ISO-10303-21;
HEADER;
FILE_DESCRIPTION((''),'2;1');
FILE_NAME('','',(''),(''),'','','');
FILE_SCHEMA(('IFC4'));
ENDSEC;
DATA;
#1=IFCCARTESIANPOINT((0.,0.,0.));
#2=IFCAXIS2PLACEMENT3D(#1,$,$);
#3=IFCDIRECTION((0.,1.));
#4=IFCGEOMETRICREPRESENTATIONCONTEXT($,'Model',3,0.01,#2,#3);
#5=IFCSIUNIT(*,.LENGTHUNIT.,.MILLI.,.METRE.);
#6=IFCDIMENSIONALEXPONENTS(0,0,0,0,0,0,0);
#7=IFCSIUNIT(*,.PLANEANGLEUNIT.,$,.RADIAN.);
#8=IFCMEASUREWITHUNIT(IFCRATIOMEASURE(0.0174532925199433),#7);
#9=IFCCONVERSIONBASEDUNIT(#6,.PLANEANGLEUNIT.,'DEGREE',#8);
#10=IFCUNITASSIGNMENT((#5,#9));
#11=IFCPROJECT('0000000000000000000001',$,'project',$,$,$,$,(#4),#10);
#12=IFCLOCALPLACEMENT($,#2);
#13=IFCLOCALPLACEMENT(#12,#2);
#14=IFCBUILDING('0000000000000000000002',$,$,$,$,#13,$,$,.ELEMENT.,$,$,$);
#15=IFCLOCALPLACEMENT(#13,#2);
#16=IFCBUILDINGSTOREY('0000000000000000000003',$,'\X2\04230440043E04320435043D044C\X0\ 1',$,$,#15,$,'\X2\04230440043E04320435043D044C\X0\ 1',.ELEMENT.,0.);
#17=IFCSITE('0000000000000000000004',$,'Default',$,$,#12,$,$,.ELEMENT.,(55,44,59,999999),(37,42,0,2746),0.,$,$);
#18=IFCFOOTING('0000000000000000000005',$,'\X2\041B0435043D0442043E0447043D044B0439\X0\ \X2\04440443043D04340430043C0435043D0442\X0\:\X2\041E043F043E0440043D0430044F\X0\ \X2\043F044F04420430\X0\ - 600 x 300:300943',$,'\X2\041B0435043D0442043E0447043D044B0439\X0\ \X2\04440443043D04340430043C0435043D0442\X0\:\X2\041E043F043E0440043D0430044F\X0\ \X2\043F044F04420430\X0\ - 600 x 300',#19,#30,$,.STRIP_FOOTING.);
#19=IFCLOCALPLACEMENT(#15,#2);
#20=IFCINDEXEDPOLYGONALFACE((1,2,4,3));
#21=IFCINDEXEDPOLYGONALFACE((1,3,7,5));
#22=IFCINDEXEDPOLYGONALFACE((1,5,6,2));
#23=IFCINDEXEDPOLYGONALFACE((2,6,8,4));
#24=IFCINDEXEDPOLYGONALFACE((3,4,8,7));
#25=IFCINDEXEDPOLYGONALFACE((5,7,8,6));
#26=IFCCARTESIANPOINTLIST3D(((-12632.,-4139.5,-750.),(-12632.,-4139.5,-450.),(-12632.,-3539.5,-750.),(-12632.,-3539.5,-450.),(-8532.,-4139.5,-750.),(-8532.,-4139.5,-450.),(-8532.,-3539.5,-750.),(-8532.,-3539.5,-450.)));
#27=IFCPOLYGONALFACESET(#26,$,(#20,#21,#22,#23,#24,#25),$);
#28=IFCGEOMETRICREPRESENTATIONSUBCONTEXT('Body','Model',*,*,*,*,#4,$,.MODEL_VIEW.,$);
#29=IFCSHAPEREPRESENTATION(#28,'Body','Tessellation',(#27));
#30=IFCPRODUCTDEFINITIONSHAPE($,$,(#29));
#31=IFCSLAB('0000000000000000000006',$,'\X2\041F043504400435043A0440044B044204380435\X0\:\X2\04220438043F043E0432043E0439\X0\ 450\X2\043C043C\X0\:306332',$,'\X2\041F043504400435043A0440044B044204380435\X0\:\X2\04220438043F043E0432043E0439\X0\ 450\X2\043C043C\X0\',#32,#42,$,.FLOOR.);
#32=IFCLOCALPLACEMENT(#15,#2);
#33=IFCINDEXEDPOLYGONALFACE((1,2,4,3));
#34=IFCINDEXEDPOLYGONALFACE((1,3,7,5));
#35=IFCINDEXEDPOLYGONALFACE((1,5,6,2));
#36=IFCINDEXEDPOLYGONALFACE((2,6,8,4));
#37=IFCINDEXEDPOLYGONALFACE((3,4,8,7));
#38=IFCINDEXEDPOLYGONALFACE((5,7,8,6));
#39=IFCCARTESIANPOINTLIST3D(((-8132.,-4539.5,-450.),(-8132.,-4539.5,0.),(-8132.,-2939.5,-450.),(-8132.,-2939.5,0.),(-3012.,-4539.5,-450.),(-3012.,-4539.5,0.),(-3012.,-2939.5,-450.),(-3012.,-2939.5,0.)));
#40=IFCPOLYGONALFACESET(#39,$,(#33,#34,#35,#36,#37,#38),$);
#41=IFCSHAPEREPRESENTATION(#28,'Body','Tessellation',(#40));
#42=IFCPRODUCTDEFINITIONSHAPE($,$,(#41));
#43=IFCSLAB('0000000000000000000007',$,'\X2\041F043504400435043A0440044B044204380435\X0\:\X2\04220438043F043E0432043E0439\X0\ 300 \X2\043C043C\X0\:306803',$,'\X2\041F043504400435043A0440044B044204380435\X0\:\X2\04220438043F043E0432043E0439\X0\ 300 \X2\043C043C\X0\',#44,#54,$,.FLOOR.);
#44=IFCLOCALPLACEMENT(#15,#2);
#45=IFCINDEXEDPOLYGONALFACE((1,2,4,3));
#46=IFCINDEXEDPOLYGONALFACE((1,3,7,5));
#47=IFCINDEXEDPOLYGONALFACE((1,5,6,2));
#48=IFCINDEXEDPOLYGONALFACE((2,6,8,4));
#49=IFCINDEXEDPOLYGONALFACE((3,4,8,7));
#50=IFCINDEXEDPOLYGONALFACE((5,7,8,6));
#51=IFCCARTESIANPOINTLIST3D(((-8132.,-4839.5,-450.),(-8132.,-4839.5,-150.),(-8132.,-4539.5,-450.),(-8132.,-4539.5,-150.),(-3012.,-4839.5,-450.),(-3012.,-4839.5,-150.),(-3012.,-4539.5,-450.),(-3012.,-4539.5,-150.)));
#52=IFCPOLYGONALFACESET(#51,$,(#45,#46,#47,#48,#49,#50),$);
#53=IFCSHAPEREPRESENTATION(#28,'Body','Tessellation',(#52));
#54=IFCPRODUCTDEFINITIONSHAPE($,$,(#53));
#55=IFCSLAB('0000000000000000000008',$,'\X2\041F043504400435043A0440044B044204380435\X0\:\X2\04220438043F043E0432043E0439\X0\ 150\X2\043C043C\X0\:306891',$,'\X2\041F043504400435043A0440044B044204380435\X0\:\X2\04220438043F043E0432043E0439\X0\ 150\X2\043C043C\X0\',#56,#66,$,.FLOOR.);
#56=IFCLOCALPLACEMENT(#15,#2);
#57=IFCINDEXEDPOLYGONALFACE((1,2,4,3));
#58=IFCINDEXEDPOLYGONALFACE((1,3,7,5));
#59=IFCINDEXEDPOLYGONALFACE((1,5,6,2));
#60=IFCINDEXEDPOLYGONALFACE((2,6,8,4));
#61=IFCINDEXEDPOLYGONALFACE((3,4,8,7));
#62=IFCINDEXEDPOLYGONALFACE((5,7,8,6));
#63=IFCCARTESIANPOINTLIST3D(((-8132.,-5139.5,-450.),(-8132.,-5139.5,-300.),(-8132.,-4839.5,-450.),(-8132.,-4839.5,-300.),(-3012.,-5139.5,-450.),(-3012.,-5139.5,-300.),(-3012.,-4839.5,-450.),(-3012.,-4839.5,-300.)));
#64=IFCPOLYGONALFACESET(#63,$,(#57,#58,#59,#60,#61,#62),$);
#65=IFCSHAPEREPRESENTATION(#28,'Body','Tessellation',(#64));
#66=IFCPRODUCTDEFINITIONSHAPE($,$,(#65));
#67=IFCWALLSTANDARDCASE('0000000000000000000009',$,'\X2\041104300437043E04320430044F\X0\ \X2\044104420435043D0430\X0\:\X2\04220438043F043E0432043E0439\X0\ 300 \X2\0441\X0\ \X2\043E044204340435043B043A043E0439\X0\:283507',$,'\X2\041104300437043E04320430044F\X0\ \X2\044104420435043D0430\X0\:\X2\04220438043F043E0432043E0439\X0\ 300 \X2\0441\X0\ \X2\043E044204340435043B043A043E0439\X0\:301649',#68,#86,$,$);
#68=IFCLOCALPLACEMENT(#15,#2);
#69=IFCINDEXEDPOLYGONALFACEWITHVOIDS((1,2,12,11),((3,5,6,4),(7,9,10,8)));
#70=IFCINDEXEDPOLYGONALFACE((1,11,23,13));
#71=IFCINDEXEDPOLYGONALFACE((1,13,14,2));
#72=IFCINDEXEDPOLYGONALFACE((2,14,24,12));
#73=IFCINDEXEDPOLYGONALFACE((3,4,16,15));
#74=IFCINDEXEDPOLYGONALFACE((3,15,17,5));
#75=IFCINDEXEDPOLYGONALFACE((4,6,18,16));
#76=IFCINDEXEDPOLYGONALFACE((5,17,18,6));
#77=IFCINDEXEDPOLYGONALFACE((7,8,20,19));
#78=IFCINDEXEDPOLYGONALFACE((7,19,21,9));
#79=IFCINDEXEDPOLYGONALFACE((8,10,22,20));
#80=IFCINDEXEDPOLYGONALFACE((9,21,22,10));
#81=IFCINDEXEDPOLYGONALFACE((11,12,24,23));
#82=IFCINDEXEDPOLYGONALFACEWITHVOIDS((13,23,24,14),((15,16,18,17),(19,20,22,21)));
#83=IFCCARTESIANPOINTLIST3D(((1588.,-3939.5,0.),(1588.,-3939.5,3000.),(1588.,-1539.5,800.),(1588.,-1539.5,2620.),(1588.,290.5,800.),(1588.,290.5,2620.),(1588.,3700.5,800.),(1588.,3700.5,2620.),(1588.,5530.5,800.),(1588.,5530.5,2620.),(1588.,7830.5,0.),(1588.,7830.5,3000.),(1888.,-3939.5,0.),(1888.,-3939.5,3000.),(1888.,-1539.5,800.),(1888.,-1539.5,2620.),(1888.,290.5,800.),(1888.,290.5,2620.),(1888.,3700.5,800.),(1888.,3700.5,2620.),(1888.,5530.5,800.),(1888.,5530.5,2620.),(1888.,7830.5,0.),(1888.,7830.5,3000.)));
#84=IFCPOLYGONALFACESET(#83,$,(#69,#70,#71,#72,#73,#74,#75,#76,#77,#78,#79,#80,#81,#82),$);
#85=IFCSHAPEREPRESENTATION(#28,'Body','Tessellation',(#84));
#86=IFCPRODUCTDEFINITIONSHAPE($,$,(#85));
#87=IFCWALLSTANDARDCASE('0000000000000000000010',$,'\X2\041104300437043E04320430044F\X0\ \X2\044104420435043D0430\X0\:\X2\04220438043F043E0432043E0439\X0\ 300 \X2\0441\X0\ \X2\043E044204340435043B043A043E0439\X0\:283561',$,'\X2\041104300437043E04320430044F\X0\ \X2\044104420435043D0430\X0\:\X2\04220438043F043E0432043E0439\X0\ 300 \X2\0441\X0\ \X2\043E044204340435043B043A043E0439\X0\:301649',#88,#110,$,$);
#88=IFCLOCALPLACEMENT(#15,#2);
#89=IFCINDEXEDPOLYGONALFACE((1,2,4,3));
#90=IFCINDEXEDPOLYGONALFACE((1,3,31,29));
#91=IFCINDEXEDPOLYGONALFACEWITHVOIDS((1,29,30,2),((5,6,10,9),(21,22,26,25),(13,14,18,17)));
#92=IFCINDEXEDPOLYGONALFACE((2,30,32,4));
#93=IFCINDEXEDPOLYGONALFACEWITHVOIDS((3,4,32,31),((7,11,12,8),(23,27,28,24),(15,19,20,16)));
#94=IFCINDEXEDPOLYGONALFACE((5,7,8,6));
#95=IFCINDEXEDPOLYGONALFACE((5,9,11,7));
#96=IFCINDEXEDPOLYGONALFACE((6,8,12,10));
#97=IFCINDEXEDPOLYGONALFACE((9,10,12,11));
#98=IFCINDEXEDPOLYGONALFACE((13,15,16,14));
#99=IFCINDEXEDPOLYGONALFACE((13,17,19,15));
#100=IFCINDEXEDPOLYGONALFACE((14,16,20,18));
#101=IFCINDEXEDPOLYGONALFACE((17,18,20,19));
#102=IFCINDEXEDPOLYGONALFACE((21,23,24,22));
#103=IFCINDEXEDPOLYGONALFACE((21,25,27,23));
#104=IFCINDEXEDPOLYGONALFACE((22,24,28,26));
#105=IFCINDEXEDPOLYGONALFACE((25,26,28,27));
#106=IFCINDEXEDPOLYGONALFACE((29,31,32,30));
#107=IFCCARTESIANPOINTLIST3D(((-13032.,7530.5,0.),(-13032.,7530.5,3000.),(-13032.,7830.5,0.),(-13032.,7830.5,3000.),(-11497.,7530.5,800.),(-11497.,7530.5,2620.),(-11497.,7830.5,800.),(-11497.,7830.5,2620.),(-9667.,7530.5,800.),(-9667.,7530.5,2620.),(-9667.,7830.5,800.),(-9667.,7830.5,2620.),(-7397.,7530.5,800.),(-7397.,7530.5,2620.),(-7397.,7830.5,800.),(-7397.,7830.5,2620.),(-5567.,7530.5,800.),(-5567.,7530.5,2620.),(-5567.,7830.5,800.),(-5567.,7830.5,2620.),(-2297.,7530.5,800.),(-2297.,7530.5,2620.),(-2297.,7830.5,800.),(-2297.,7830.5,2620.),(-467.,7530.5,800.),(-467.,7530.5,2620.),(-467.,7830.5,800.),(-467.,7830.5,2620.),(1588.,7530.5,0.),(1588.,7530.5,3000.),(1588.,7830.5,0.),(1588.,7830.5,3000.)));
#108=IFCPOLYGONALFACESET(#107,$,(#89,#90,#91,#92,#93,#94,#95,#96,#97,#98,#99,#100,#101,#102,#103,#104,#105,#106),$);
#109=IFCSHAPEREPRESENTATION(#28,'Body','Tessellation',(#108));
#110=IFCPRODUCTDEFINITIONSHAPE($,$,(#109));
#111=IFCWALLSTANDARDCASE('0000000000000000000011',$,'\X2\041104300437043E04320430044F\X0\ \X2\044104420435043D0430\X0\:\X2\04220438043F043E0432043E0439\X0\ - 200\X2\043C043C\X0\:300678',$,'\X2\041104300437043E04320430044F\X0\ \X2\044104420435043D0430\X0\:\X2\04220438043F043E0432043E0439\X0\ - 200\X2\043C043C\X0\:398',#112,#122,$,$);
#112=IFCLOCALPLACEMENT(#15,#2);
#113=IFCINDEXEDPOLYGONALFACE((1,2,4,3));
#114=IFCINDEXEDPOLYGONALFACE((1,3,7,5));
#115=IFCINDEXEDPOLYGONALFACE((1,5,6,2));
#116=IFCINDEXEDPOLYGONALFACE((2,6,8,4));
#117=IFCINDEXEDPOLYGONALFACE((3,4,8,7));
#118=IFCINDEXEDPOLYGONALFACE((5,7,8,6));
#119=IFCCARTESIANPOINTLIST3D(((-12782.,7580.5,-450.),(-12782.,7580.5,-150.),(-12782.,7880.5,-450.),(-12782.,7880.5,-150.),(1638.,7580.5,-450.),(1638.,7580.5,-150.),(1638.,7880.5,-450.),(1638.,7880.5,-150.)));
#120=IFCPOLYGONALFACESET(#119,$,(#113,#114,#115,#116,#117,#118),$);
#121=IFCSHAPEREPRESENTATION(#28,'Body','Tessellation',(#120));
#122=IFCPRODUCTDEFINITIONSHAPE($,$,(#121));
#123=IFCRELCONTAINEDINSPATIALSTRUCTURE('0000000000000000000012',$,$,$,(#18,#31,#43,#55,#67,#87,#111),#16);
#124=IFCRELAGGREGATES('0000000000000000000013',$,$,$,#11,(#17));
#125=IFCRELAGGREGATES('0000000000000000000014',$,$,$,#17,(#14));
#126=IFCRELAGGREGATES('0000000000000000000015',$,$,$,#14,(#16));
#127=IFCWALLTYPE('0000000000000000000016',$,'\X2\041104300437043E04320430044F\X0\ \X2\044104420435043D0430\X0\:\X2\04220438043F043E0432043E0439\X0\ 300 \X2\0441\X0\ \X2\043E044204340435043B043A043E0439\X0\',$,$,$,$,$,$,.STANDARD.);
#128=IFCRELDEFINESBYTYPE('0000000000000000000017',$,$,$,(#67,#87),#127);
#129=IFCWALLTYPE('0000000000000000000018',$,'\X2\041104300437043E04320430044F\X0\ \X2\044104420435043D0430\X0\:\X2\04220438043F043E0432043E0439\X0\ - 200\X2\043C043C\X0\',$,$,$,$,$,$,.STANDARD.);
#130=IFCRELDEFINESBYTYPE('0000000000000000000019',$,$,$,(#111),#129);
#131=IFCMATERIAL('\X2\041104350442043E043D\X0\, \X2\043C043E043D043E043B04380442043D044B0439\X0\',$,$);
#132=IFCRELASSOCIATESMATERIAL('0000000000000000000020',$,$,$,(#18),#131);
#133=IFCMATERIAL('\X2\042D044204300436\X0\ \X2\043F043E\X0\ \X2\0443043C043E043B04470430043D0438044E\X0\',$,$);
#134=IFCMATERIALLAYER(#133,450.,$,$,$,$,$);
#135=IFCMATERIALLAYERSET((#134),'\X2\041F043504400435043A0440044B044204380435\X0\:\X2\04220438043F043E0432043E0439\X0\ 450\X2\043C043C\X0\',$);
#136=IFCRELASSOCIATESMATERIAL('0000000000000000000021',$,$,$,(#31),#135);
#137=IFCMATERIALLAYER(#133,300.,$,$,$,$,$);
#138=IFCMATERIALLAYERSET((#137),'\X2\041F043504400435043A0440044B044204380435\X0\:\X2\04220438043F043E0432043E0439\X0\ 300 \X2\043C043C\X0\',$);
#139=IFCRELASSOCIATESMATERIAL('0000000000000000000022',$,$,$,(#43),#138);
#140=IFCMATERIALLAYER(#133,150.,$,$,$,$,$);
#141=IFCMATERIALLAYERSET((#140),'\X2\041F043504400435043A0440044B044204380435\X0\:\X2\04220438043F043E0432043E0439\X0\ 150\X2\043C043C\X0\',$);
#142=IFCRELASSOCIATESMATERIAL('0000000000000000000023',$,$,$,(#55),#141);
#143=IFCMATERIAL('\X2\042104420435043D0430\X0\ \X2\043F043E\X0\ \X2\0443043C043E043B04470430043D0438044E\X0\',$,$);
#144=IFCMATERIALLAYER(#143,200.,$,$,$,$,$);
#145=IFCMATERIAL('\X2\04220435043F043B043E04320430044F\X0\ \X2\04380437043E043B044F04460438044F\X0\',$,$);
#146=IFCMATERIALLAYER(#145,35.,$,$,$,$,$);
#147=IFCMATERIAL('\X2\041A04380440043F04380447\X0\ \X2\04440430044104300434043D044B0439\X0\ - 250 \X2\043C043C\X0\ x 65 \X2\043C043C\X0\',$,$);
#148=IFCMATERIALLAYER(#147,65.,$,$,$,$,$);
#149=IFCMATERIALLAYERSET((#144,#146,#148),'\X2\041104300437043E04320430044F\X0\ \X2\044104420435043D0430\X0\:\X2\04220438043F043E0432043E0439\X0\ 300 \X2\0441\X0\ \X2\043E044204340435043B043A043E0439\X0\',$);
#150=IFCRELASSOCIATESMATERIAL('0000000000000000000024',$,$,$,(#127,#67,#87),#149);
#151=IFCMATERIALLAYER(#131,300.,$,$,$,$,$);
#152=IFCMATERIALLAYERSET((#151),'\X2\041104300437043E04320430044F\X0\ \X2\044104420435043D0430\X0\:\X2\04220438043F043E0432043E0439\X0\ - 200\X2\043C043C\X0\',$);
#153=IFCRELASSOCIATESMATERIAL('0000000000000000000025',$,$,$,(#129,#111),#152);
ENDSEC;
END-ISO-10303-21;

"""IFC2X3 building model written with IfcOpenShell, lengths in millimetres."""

from ifc_helpers import new_model, entity, si_unit, converted_unit, direction, frame, frame_2d, origin, place, context, subcontext, project, spatial, polyline, rectangle, extrude, clip, halfspace, bounded_halfspace, material, layer, layer_set, layer_usage, type_object, element, save


model = new_model("IFC2X3")

# Units and contexts
model_context = context("Model", 3, precision=0.01, world=origin(), true_north=direction((0.0, 1.0)))
body_context = subcontext(model_context, "Body", "Model", "MODEL_VIEW")
ifc_project = project(units=[si_unit("LENGTHUNIT", "METRE", prefix="MILLI"), converted_unit("PLANEANGLEUNIT", "DEGREE", entity("IfcRatioMeasure", 0.0174532925199433), si_unit("PLANEANGLEUNIT", "RADIAN"), dimensions=[0, 0, 0, 0, 0, 0, 0])], contexts=[model_context])

# Site, building, storey
site_placement = place(None, origin())
site = spatial("IfcSite", under=ifc_project, at=site_placement, Name="Default", CompositionType="ELEMENT", RefLatitude=(55, 44, 59, 999999), RefLongitude=(37, 42, 0, 2746), RefElevation=0.0)
building_placement = place(site_placement, origin())
building = spatial("IfcBuilding", under=site, at=building_placement, CompositionType="ELEMENT")
storey_placement = place(building_placement, origin())
storey = spatial("IfcBuildingStorey", under=building, at=storey_placement, Name="Уровень 1", LongName="Уровень 1", CompositionType="ELEMENT", Elevation=0.0)

# Footing
ifc_material_1 = material(Name="Бетон, монолитный")
footing_1_placement = place(storey_placement, origin())
element("IfcFooting", 1, at=footing_1_placement, inside=storey, material=ifc_material_1, Name="Ленточный фундамент:Опорная пята - 600 x 300:300943", ObjectType="Ленточный фундамент:Опорная пята - 600 x 300", PredefinedType="STRIP_FOOTING", context=body_context, shape_type="SweptSolid", body=[
    extrude(rectangle(XDim=4100.0, YDim=600.0, at=frame_2d((0.0, 0.0), x_axis=(1.0, 0.0))), frame((-10582.0, -3839.5, -750.0)), (0.0, 0.0, 1.0), 300.0),
])

# Slabs
ifc_material_2 = material(Name="Этаж по умолчанию")
ifc_layer_1 = layer(ifc_material_2, 450.0)
ifc_layer_set_1 = layer_set([ifc_layer_1], Name="Перекрытие:Типовой 450мм")
ifc_layer_usage_1 = layer_usage(ifc_layer_set_1, "AXIS3", "POSITIVE", 0.0)
slab_1_placement = place(storey_placement, origin())
element("IfcSlab", 2, at=slab_1_placement, inside=storey, material=ifc_layer_usage_1, Name="Перекрытие:Типовой 450мм:306332", ObjectType="Перекрытие:Типовой 450мм", PredefinedType="FLOOR", context=body_context, shape_type="SweptSolid", body=[
    extrude(rectangle(XDim=1600.0, YDim=5120.0, at=frame_2d((0.0, 0.0), x_axis=(1.0, 0.0))), frame((-5572.0, -3739.5, 0.0), z_axis=(0.0, 0.0, -1.0), x_axis=(0.0, 1.0, 0.0)), (0.0, 0.0, 1.0), 450.0),
])
ifc_layer_2 = layer(ifc_material_2, 300.0)
ifc_layer_set_2 = layer_set([ifc_layer_2], Name="Перекрытие:Типовой 300 мм")
ifc_layer_usage_2 = layer_usage(ifc_layer_set_2, "AXIS3", "POSITIVE", 0.0)
slab_2_placement = place(storey_placement, origin())
element("IfcSlab", 3, at=slab_2_placement, inside=storey, material=ifc_layer_usage_2, Name="Перекрытие:Типовой 300 мм:306803", ObjectType="Перекрытие:Типовой 300 мм", PredefinedType="FLOOR", context=body_context, shape_type="SweptSolid", body=[
    extrude(rectangle(XDim=300.0, YDim=5120.0, at=frame_2d((0.0, 0.0), x_axis=(1.0, 0.0))), frame((-5572.0, -4689.5, -150.0), z_axis=(0.0, 0.0, -1.0), x_axis=(0.0, 1.0, 0.0)), (0.0, 0.0, 1.0), 300.0),
])
ifc_layer_3 = layer(ifc_material_2, 150.0)
ifc_layer_set_3 = layer_set([ifc_layer_3], Name="Перекрытие:Типовой 150мм")
ifc_layer_usage_3 = layer_usage(ifc_layer_set_3, "AXIS3", "POSITIVE", 0.0)
slab_3_placement = place(storey_placement, origin())
element("IfcSlab", 4, at=slab_3_placement, inside=storey, material=ifc_layer_usage_3, Name="Перекрытие:Типовой 150мм:306891", ObjectType="Перекрытие:Типовой 150мм", PredefinedType="FLOOR", context=body_context, shape_type="SweptSolid", body=[
    extrude(rectangle(XDim=300.0, YDim=5120.0, at=frame_2d((0.0, 0.0), x_axis=(1.0, 0.0))), frame((-5572.0, -4989.5, -300.0), z_axis=(0.0, 0.0, -1.0), x_axis=(0.0, 1.0, 0.0)), (0.0, 0.0, 1.0), 150.0),
])

# Walls, openings
ifc_material_3 = material(Name="Стена по умолчанию")
ifc_layer_4 = layer(ifc_material_3, 200.0)
ifc_material_4 = material(Name="Тепловая изоляция")
ifc_layer_5 = layer(ifc_material_4, 35.0)
ifc_material_5 = material(Name="Кирпич фасадный - 250 мм x 65 мм")
ifc_layer_6 = layer(ifc_material_5, 65.0)
ifc_layer_set_4 = layer_set([ifc_layer_4, ifc_layer_5, ifc_layer_6], Name="Базовая стена:Типовой 300 с отделкой")
ifc_layer_usage_4 = layer_usage(ifc_layer_set_4, "AXIS2", "NEGATIVE", 150.0)
wall_type_1 = type_object("IfcWallType", Name="Базовая стена:Типовой 300 с отделкой", PredefinedType="STANDARD", material=ifc_layer_set_4)
wall_1_placement = place(storey_placement, frame((1738.0, -3939.5, 0.0), z_axis=(0.0, 0.0, 1.0), x_axis=(0.0, 1.0, 0.0)))
wall_1 = element("IfcWallStandardCase", 5, at=wall_1_placement, inside=storey, type_object=wall_type_1, material=ifc_layer_usage_4, Name="Базовая стена:Типовой 300 с отделкой:283507", ObjectType="Базовая стена:Типовой 300 с отделкой:301649", context=body_context, shape_type="Clipping", body=[
    clip(extrude(rectangle(XDim=11770.0, YDim=300.0, at=frame_2d((5885.0, 0.0), x_axis=(-1.0, 0.0))), origin(), (0.0, 0.0, 1.0), 3000.0), halfspace(origin(), True)),
])
opening_1_placement = place(wall_1_placement, frame((4230.0, 150.0, 800.0)))
element("IfcOpeningElement", 6, at=opening_1_placement, cuts=wall_1, ObjectType="Opening", context=body_context, shape_type="SweptSolid", body=[
    extrude(rectangle(XDim=1820.0, YDim=1830.0, at=frame_2d((910.0, 915.0), x_axis=(1.0, 0.0))), frame((0.0, 0.0, 0.0), z_axis=(0.0, -1.0, 0.0), x_axis=(0.0, 0.0, 1.0)), (0.0, 0.0, 1.0), 300.0),
])
opening_2_placement = place(wall_1_placement, frame((9470.0, 150.0, 800.0)))
element("IfcOpeningElement", 7, at=opening_2_placement, cuts=wall_1, ObjectType="Opening", context=body_context, shape_type="SweptSolid", body=[
    extrude(rectangle(XDim=1820.0, YDim=1830.0, at=frame_2d((910.0, 915.0), x_axis=(1.0, 0.0))), frame((0.0, 0.0, 0.0), z_axis=(0.0, -1.0, 0.0), x_axis=(0.0, 0.0, 1.0)), (0.0, 0.0, 1.0), 300.0),
])
ifc_layer_usage_5 = layer_usage(ifc_layer_set_4, "AXIS2", "NEGATIVE", 150.0)
wall_2_placement = place(storey_placement, frame((1588.0, 7680.5, 0.0), z_axis=(0.0, 0.0, 1.0), x_axis=(-1.0, 0.0, 0.0)))
wall_2 = element("IfcWallStandardCase", 8, at=wall_2_placement, inside=storey, type_object=wall_type_1, material=ifc_layer_usage_5, Name="Базовая стена:Типовой 300 с отделкой:283561", ObjectType="Базовая стена:Типовой 300 с отделкой:301649", context=body_context, shape_type="Clipping", body=[
    clip(extrude(rectangle(XDim=14620.0, YDim=300.0, at=frame_2d((7310.0, 0.0), x_axis=(-1.0, 0.0))), origin(), (0.0, 0.0, 1.0), 3000.0), halfspace(origin(), True)),
])
opening_3_placement = place(wall_2_placement, frame((13085.0, 150.0, 800.0)))
element("IfcOpeningElement", 9, at=opening_3_placement, cuts=wall_2, ObjectType="Opening", context=body_context, shape_type="SweptSolid", body=[
    extrude(rectangle(XDim=1820.0, YDim=1830.0, at=frame_2d((910.0, 915.0), x_axis=(1.0, 0.0))), frame((0.0, 0.0, 0.0), z_axis=(0.0, -1.0, 0.0), x_axis=(0.0, 0.0, 1.0)), (0.0, 0.0, 1.0), 300.0),
])
opening_4_placement = place(wall_2_placement, frame((8985.0, 150.0, 800.0)))
element("IfcOpeningElement", 10, at=opening_4_placement, cuts=wall_2, ObjectType="Opening", context=body_context, shape_type="SweptSolid", body=[
    extrude(rectangle(XDim=1820.0, YDim=1830.0, at=frame_2d((910.0, 915.0), x_axis=(1.0, 0.0))), frame((0.0, 0.0, 0.0), z_axis=(0.0, -1.0, 0.0), x_axis=(0.0, 0.0, 1.0)), (0.0, 0.0, 1.0), 300.0),
])
opening_5_placement = place(wall_2_placement, frame((3885.0, 150.0, 800.0)))
element("IfcOpeningElement", 11, at=opening_5_placement, cuts=wall_2, ObjectType="Opening", context=body_context, shape_type="SweptSolid", body=[
    extrude(rectangle(XDim=1820.0, YDim=1830.0, at=frame_2d((910.0, 915.0), x_axis=(1.0, 0.0))), frame((0.0, 0.0, 0.0), z_axis=(0.0, -1.0, 0.0), x_axis=(0.0, 0.0, 1.0)), (0.0, 0.0, 1.0), 300.0),
])

# Wall
ifc_layer_7 = layer(ifc_material_1, 300.0)
ifc_layer_set_5 = layer_set([ifc_layer_7], Name="Базовая стена:Типовой - 200мм")
wall_type_2 = type_object("IfcWallType", Name="Базовая стена:Типовой - 200мм", PredefinedType="STANDARD", material=ifc_layer_set_5)
ifc_layer_usage_6 = layer_usage(ifc_layer_set_5, "AXIS2", "NEGATIVE", 150.0)
wall_3_placement = place(storey_placement, frame((1638.0, 7730.5, -450.0), z_axis=(0.0, 0.0, 1.0), x_axis=(-1.0, 0.0, 0.0)))
element("IfcWallStandardCase", 12, at=wall_3_placement, inside=storey, type_object=wall_type_2, material=ifc_layer_usage_6, Name="Базовая стена:Типовой - 200мм:300678", ObjectType="Базовая стена:Типовой - 200мм:398", context=body_context, shape_type="Clipping", body=[
    clip(extrude(rectangle(XDim=14420.0, YDim=300.0, at=frame_2d((7210.0, 0.0), x_axis=(-1.0, 0.0))), origin(), (0.0, 0.0, 1.0), 300.0), bounded_halfspace(frame((14420.0, -100.0, 300.0), z_axis=(0.0, 0.0, -1.0), x_axis=(0.0, 1.0, 0.0)), True, frame((14420.0, -100.0, 300.0)), polyline([(0.0, 0.0), (0.0, 250.0), (-14420.0, 250.0), (-14420.0, 0.0), (0.0, 0.0)]))),
])

save(model, "model.ifc")
